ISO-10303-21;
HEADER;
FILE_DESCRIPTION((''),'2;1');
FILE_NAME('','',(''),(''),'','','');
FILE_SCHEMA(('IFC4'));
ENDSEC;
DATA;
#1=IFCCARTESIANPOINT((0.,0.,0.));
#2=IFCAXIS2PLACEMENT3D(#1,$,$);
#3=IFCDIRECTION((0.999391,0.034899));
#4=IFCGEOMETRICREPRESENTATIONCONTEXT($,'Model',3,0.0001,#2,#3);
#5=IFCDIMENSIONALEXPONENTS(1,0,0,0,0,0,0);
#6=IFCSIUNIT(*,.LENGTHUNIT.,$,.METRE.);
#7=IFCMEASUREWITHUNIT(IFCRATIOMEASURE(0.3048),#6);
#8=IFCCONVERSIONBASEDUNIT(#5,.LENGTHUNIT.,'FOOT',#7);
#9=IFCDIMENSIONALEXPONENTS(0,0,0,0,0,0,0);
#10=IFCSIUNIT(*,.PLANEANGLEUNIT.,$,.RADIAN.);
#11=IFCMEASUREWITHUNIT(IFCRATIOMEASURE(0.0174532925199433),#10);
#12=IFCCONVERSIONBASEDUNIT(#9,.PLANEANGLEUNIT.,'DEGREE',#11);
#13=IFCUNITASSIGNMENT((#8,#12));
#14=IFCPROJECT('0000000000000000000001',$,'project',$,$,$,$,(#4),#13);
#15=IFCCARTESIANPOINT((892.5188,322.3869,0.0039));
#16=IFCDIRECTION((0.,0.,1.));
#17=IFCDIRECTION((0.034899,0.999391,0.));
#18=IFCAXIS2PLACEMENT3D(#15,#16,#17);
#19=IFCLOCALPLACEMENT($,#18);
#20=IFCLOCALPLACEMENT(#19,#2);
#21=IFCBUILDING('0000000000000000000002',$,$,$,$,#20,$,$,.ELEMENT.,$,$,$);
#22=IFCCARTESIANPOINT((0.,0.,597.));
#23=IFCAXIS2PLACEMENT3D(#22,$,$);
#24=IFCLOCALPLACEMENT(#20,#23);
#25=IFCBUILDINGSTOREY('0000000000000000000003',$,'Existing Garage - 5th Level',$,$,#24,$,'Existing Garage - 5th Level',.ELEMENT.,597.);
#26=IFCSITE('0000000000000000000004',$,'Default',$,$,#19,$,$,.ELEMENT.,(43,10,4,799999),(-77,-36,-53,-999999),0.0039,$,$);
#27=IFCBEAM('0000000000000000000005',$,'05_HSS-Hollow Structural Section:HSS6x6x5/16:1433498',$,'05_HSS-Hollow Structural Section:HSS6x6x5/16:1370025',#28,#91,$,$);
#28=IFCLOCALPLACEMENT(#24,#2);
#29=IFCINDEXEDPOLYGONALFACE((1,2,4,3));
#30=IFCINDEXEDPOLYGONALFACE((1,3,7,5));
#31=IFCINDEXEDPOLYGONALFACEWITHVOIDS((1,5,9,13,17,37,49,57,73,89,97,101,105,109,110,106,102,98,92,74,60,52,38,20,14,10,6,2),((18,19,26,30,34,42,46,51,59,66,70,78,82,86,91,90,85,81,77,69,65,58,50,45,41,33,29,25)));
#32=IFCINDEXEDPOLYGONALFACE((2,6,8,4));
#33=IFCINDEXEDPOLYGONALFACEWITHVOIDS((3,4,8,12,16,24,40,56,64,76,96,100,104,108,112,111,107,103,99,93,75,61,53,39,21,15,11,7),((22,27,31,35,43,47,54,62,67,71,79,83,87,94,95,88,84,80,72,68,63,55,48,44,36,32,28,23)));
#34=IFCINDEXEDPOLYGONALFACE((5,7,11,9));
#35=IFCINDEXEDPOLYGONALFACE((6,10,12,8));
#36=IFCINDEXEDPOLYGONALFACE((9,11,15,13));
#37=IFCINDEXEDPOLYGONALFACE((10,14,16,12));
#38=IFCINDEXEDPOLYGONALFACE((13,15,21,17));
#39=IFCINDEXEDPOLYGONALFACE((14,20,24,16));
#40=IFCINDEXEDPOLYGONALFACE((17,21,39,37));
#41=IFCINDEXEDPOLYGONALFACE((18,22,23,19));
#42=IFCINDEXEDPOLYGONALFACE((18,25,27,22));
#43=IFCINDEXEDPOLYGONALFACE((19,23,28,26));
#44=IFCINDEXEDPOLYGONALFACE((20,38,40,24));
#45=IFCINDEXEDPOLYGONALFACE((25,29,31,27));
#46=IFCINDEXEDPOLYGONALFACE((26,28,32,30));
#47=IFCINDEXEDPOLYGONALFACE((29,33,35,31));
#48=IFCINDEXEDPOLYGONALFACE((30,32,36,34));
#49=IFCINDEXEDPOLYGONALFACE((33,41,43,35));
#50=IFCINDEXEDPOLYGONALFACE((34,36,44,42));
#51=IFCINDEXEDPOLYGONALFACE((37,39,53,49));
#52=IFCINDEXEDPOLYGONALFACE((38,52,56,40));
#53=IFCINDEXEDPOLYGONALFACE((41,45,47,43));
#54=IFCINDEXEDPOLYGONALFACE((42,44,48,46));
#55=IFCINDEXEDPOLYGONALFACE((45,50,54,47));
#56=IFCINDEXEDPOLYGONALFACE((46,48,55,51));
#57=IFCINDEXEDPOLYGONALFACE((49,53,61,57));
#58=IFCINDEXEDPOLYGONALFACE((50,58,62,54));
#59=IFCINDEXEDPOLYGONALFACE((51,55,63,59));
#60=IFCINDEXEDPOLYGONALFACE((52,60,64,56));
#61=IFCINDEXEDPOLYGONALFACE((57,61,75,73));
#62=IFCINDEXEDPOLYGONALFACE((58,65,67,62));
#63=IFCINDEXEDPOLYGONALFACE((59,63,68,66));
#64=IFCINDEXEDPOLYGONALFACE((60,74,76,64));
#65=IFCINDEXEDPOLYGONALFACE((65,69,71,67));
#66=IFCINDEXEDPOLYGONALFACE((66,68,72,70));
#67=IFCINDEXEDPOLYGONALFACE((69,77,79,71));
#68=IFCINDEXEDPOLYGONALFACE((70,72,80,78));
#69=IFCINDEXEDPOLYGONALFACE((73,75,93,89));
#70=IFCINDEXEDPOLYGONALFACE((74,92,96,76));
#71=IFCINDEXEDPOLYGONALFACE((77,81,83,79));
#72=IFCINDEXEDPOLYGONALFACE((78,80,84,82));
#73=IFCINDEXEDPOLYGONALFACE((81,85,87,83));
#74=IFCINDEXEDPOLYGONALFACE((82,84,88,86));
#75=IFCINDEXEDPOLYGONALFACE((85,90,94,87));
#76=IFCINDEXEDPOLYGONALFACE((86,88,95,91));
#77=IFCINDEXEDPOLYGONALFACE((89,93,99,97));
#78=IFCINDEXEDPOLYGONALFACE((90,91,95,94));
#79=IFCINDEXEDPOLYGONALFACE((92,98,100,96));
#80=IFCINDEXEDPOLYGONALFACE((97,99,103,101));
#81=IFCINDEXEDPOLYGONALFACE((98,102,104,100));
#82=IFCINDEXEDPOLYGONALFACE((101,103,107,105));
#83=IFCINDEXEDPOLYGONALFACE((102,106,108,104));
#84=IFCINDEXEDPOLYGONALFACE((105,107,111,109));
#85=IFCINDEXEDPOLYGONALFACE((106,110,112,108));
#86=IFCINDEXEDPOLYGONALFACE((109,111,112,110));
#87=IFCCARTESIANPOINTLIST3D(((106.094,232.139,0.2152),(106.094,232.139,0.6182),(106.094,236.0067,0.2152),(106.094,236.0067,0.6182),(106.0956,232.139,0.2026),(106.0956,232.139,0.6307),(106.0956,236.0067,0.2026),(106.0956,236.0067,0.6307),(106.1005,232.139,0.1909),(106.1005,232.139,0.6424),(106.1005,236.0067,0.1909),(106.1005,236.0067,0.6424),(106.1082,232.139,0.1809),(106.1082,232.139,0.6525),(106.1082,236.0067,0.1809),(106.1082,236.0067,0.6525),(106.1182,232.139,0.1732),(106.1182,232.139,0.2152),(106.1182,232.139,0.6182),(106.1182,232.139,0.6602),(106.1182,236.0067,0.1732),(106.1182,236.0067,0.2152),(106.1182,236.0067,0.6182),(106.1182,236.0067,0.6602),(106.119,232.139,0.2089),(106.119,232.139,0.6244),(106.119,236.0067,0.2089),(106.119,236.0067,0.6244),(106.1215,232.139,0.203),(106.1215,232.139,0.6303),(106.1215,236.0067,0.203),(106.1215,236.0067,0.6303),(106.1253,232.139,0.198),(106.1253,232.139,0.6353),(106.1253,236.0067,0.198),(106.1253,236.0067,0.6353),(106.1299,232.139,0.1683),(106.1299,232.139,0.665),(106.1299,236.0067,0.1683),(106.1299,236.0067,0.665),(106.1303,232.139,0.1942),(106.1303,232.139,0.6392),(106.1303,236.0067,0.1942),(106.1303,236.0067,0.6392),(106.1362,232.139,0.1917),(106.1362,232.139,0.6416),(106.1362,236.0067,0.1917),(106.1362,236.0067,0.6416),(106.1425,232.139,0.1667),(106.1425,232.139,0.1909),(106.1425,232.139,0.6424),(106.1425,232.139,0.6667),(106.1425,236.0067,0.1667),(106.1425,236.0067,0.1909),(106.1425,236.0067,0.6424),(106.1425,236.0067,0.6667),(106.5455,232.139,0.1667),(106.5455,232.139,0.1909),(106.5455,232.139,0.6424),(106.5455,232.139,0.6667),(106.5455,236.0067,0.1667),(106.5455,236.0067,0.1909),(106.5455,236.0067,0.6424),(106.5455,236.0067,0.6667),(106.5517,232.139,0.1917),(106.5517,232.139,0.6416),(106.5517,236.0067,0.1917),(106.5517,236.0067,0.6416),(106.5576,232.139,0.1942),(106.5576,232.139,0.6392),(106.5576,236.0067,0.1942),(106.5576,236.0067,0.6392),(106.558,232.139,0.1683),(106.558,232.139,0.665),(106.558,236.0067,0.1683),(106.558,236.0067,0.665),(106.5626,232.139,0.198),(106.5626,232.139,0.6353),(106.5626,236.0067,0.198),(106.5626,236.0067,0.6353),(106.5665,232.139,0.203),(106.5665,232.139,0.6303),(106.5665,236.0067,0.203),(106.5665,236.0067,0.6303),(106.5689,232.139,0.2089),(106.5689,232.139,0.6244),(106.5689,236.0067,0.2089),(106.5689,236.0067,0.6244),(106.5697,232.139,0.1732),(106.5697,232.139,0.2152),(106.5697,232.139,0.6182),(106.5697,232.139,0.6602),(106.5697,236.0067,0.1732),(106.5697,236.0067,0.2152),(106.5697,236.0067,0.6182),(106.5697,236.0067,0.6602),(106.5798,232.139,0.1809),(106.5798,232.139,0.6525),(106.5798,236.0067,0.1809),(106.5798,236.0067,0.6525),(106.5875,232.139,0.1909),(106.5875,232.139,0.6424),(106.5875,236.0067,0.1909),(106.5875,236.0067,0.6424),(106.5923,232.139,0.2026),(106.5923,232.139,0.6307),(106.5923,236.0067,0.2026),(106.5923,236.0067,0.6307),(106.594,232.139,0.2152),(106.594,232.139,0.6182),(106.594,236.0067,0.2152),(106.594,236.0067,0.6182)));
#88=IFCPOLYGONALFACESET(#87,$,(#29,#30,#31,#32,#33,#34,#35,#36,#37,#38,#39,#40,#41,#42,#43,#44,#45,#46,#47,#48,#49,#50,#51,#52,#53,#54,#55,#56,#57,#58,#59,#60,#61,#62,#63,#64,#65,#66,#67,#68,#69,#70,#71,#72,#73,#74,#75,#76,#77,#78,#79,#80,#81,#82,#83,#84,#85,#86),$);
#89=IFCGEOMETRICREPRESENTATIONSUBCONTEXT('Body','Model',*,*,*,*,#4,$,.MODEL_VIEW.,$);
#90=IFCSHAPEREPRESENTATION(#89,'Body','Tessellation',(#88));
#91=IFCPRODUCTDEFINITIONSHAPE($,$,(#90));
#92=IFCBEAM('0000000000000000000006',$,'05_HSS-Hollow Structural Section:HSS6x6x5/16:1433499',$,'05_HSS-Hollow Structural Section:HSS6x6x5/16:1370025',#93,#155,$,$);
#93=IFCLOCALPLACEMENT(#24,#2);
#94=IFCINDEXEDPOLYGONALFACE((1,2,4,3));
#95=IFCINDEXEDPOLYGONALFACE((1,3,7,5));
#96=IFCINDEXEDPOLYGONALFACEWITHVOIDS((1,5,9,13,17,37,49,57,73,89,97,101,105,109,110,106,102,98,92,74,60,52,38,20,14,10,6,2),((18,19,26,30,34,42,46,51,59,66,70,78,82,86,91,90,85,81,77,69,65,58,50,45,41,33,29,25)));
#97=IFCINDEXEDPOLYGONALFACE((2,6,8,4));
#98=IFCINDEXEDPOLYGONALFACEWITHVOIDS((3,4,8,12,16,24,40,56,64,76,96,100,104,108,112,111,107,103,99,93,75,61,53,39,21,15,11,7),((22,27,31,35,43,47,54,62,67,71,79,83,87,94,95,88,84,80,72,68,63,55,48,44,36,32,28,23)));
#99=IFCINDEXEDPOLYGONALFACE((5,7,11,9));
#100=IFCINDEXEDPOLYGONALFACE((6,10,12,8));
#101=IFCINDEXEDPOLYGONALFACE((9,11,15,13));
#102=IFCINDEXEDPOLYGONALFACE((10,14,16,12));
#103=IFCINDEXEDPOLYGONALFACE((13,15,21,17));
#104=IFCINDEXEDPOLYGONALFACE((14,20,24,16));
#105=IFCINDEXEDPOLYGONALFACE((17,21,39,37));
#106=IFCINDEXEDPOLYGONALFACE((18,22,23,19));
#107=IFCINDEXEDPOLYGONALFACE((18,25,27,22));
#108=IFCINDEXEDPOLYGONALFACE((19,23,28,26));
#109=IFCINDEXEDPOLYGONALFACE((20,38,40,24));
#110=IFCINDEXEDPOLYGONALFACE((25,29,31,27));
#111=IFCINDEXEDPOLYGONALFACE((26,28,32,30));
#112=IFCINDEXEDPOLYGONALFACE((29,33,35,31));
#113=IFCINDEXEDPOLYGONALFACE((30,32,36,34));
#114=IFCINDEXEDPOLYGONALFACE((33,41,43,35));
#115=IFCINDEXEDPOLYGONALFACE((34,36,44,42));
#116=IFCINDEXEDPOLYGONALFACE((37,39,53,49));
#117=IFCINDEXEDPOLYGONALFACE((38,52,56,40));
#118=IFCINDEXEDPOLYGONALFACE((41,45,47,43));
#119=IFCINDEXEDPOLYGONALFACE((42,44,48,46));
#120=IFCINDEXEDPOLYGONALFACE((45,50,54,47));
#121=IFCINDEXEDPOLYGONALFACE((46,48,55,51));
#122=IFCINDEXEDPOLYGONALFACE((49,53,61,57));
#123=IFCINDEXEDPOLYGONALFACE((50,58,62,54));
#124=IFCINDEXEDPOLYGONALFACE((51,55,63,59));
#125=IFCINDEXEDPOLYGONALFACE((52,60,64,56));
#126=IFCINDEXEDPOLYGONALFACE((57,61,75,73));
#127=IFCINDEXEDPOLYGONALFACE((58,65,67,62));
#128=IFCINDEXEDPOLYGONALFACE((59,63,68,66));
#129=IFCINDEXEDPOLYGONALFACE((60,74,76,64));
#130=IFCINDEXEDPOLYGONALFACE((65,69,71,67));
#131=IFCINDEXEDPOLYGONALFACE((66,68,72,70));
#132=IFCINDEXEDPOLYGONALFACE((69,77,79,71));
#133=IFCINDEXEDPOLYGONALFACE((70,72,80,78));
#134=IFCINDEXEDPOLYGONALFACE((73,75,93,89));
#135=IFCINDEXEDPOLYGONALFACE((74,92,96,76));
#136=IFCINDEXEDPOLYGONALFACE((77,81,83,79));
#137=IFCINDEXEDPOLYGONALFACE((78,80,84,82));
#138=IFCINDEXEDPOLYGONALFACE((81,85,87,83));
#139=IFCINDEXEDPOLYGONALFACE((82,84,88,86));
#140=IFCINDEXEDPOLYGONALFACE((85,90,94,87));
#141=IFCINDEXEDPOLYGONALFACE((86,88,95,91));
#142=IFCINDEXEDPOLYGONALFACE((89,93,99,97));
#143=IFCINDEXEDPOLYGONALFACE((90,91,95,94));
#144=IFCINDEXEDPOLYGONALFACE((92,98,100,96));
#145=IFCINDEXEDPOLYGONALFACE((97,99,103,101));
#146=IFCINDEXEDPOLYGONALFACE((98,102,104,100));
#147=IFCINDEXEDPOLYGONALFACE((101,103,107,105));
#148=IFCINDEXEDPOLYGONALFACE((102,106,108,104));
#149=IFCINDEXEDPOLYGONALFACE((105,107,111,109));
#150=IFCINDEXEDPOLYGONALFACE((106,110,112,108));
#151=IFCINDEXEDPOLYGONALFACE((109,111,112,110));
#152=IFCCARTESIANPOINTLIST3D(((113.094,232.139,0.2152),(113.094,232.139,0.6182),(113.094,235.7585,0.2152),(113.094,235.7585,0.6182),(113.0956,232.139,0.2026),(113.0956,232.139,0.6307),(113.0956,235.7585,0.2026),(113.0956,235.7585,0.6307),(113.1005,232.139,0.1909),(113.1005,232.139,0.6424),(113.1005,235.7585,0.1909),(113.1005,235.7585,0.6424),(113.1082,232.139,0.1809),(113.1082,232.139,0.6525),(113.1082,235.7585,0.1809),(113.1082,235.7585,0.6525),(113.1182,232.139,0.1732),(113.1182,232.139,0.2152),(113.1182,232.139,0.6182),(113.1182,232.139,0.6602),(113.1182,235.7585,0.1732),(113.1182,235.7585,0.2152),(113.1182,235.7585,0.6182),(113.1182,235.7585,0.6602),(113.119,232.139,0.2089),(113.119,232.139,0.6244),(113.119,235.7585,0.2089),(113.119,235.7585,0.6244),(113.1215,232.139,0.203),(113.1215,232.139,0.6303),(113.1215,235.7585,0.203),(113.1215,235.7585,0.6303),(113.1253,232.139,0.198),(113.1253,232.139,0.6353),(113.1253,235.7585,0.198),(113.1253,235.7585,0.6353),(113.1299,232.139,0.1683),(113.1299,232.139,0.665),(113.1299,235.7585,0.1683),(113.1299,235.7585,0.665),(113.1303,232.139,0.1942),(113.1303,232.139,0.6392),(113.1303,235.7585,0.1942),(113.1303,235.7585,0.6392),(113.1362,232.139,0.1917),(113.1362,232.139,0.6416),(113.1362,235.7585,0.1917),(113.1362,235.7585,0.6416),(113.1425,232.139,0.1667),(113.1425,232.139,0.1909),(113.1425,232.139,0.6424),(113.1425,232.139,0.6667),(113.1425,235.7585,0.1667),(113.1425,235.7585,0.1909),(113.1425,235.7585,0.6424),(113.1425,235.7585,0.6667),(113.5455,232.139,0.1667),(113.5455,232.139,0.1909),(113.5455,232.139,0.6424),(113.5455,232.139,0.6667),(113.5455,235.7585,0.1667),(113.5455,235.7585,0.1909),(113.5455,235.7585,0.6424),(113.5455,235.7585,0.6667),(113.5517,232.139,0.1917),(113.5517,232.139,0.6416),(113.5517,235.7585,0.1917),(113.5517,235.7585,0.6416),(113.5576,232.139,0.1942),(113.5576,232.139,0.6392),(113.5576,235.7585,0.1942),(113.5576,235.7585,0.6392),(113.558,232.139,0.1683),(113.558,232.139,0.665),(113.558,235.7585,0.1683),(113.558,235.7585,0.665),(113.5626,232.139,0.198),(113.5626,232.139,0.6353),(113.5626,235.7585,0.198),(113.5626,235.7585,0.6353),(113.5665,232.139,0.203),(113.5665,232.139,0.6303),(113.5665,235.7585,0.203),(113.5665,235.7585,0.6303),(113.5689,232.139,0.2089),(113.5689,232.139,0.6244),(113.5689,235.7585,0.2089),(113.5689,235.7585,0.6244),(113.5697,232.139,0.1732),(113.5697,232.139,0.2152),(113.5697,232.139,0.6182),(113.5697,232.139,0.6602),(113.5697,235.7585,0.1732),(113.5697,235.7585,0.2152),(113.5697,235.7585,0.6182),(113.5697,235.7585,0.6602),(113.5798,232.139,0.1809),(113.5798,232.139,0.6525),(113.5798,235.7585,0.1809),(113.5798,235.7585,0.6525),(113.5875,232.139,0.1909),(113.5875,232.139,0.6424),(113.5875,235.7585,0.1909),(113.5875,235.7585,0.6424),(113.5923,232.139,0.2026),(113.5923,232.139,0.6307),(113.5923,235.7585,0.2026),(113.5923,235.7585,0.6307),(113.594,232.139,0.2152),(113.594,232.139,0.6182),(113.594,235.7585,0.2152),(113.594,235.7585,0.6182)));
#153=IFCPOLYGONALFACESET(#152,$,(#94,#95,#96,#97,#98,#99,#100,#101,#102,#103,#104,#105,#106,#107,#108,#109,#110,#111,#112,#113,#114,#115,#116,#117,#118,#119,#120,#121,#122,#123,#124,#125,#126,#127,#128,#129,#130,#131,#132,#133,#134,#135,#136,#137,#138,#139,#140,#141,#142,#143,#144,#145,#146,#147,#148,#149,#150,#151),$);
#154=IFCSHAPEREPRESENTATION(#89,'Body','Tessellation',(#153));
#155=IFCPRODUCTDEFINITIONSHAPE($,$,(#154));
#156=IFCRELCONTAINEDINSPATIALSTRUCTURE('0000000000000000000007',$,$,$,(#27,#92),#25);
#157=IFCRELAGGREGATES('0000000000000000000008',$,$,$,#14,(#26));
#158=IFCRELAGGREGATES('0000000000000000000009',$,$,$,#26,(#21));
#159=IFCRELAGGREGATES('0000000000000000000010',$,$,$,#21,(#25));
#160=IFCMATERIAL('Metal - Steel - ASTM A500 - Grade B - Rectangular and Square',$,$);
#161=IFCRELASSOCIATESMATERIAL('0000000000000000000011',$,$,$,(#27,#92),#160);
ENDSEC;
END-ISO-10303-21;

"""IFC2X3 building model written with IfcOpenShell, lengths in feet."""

from ifc_helpers import new_model, entity, si_unit, converted_unit, direction, frame, frame_2d, origin, place, context, subcontext, project, spatial, polyline, circle_curve, parameter, trimmed, segment, composite_curve, outline, extrude, material, element, save


model = new_model("IFC2X3")

# Units and contexts
model_context = context("Model", 3, precision=0.0001, world=origin(), true_north=direction((0.999391, 0.034899)))
body_context = subcontext(model_context, "Body", "Model", "MODEL_VIEW")
ifc_project = project(units=[converted_unit("LENGTHUNIT", "FOOT", entity("IfcRatioMeasure", 0.3048), si_unit("LENGTHUNIT", "METRE"), dimensions=[1, 0, 0, 0, 0, 0, 0]), converted_unit("PLANEANGLEUNIT", "DEGREE", entity("IfcRatioMeasure", 0.0174532925199433), si_unit("PLANEANGLEUNIT", "RADIAN"), dimensions=[0, 0, 0, 0, 0, 0, 0])], contexts=[model_context])

# Site, building, storey
site_placement = place(None, frame((892.5188, 322.3869, 0.0039), z_axis=(0.0, 0.0, 1.0), x_axis=(0.034899, 0.999391, 0.0)))
site = spatial("IfcSite", under=ifc_project, at=site_placement, Name="Default", CompositionType="ELEMENT", RefLatitude=(43, 10, 4, 799999), RefLongitude=(-77, -36, -53, -999999), RefElevation=0.0039)
building_placement = place(site_placement, origin())
building = spatial("IfcBuilding", under=site, at=building_placement, CompositionType="ELEMENT")
storey_placement = place(building_placement, frame((0.0, 0.0, 597.0)))
storey = spatial("IfcBuildingStorey", under=building, at=storey_placement, Name="Existing Garage - 5th Level", LongName="Existing Garage - 5th Level", CompositionType="ELEMENT", Elevation=597.0)

# Beams
ifc_material_1 = material(Name="Metal - Steel - ASTM A500 - Grade B - Rectangular and Square")
beam_1_placement = place(storey_placement, frame((106.344, 231.8473, 0.6667), z_axis=(0.0, 0.0, 1.0), x_axis=(0.0, 1.0, 0.0)))
element("IfcBeam", 1, at=beam_1_placement, inside=storey, material=ifc_material_1, Name="05_HSS-Hollow Structural Section:HSS6x6x5/16:1433498", ObjectType="05_HSS-Hollow Structural Section:HSS6x6x5/16:1370025", context=body_context, shape_type="SweptSolid", body=[
    extrude(outline(composite_curve([segment(trimmed(circle_curve(frame_2d((-0.2015, -0.2015), x_axis=(1.0, 0.0)), 0.0485), [parameter(180.0)], [parameter(270.0)], True, "PARAMETER"), True, "CONTINUOUS"), segment(polyline([(-0.2015, -0.25), (0.2015, -0.25)]), True, "CONTINUOUS"), segment(trimmed(circle_curve(frame_2d((0.2015, -0.2015), x_axis=(1.0, 0.0)), 0.0485), [parameter(270.0)], [parameter(0.0)], True, "PARAMETER"), True, "CONTINUOUS"), segment(polyline([(0.25, -0.2015), (0.25, 0.2015)]), True, "CONTINUOUS"), segment(trimmed(circle_curve(frame_2d((0.2015, 0.2015), x_axis=(1.0, 0.0)), 0.0485), [parameter(360.0)], [parameter(90.0)], True, "PARAMETER"), True, "CONTINUOUS"), segment(polyline([(0.2015, 0.25), (-0.2015, 0.25)]), True, "CONTINUOUS"), segment(trimmed(circle_curve(frame_2d((-0.2015, 0.2015), x_axis=(1.0, 0.0)), 0.0485), [parameter(90.0)], [parameter(180.0)], True, "PARAMETER"), True, "CONTINUOUS"), segment(polyline([(-0.25, 0.2015), (-0.25, -0.2015)]), True, "CONTINUOUS")], self_intersect=False), holes=[composite_curve([segment(polyline([(0.2015, -0.2257), (-0.2015, -0.2257)]), True, "CONTINUOUS"), segment(trimmed(circle_curve(frame_2d((-0.2015, -0.2015), x_axis=(1.0, 0.0)), 0.0243), [parameter(180.0)], [parameter(270.0)], True, "PARAMETER"), False, "CONTINUOUS"), segment(polyline([(-0.2258, -0.2015), (-0.2258, 0.2015)]), True, "CONTINUOUS"), segment(trimmed(circle_curve(frame_2d((-0.2015, 0.2015), x_axis=(1.0, 0.0)), 0.0243), [parameter(90.0)], [parameter(180.0)], True, "PARAMETER"), False, "CONTINUOUS"), segment(polyline([(-0.2015, 0.2258), (0.2015, 0.2258)]), True, "CONTINUOUS"), segment(trimmed(circle_curve(frame_2d((0.2015, 0.2015), x_axis=(1.0, 0.0)), 0.0243), [parameter(0.0)], [parameter(90.0)], True, "PARAMETER"), False, "CONTINUOUS"), segment(polyline([(0.2257, 0.2015), (0.2257, -0.2015)]), True, "CONTINUOUS"), segment(trimmed(circle_curve(frame_2d((0.2015, -0.2015), x_axis=(1.0, 0.0)), 0.0243), [parameter(270.0)], [parameter(0.0)], True, "PARAMETER"), False, "CONTINUOUS")], self_intersect=False)]), frame((0.2917, 0.0, -0.25), z_axis=(1.0, 0.0, 0.0), x_axis=(0.0, -1.0, 0.0)), (0.0, 0.0, 1.0), 3.8677),
])
beam_2_placement = place(storey_placement, frame((113.344, 231.8473, 0.6667), z_axis=(0.0, 0.0, 1.0), x_axis=(0.0, 1.0, 0.0)))
element("IfcBeam", 2, at=beam_2_placement, inside=storey, material=ifc_material_1, Name="05_HSS-Hollow Structural Section:HSS6x6x5/16:1433499", ObjectType="05_HSS-Hollow Structural Section:HSS6x6x5/16:1370025", context=body_context, shape_type="SweptSolid", body=[
    extrude(outline(composite_curve([segment(trimmed(circle_curve(frame_2d((-0.2015, -0.2015), x_axis=(1.0, 0.0)), 0.0485), [parameter(180.0)], [parameter(270.0)], True, "PARAMETER"), True, "CONTINUOUS"), segment(polyline([(-0.2015, -0.25), (0.2015, -0.25)]), True, "CONTINUOUS"), segment(trimmed(circle_curve(frame_2d((0.2015, -0.2015), x_axis=(1.0, 0.0)), 0.0485), [parameter(270.0)], [parameter(0.0)], True, "PARAMETER"), True, "CONTINUOUS"), segment(polyline([(0.25, -0.2015), (0.25, 0.2015)]), True, "CONTINUOUS"), segment(trimmed(circle_curve(frame_2d((0.2015, 0.2015), x_axis=(1.0, 0.0)), 0.0485), [parameter(360.0)], [parameter(90.0)], True, "PARAMETER"), True, "CONTINUOUS"), segment(polyline([(0.2015, 0.25), (-0.2015, 0.25)]), True, "CONTINUOUS"), segment(trimmed(circle_curve(frame_2d((-0.2015, 0.2015), x_axis=(1.0, 0.0)), 0.0485), [parameter(90.0)], [parameter(180.0)], True, "PARAMETER"), True, "CONTINUOUS"), segment(polyline([(-0.25, 0.2015), (-0.25, -0.2015)]), True, "CONTINUOUS")], self_intersect=False), holes=[composite_curve([segment(polyline([(0.2015, -0.2257), (-0.2015, -0.2257)]), True, "CONTINUOUS"), segment(trimmed(circle_curve(frame_2d((-0.2015, -0.2015), x_axis=(1.0, 0.0)), 0.0243), [parameter(180.0)], [parameter(270.0)], True, "PARAMETER"), False, "CONTINUOUS"), segment(polyline([(-0.2257, -0.2015), (-0.2257, 0.2015)]), True, "CONTINUOUS"), segment(trimmed(circle_curve(frame_2d((-0.2015, 0.2015), x_axis=(1.0, 0.0)), 0.0243), [parameter(90.0)], [parameter(180.0)], True, "PARAMETER"), False, "CONTINUOUS"), segment(polyline([(-0.2015, 0.2258), (0.2015, 0.2258)]), True, "CONTINUOUS"), segment(trimmed(circle_curve(frame_2d((0.2015, 0.2015), x_axis=(1.0, 0.0)), 0.0243), [parameter(0.0)], [parameter(90.0)], True, "PARAMETER"), False, "CONTINUOUS"), segment(polyline([(0.2258, 0.2015), (0.2258, -0.2015)]), True, "CONTINUOUS"), segment(trimmed(circle_curve(frame_2d((0.2015, -0.2015), x_axis=(1.0, 0.0)), 0.0243), [parameter(270.0)], [parameter(0.0)], True, "PARAMETER"), False, "CONTINUOUS")], self_intersect=False)]), frame((0.2917, 0.0, -0.25), z_axis=(1.0, 0.0, 0.0), x_axis=(0.0, -1.0, 0.0)), (0.0, 0.0, 1.0), 3.6195),
])

save(model, "model.ifc")
